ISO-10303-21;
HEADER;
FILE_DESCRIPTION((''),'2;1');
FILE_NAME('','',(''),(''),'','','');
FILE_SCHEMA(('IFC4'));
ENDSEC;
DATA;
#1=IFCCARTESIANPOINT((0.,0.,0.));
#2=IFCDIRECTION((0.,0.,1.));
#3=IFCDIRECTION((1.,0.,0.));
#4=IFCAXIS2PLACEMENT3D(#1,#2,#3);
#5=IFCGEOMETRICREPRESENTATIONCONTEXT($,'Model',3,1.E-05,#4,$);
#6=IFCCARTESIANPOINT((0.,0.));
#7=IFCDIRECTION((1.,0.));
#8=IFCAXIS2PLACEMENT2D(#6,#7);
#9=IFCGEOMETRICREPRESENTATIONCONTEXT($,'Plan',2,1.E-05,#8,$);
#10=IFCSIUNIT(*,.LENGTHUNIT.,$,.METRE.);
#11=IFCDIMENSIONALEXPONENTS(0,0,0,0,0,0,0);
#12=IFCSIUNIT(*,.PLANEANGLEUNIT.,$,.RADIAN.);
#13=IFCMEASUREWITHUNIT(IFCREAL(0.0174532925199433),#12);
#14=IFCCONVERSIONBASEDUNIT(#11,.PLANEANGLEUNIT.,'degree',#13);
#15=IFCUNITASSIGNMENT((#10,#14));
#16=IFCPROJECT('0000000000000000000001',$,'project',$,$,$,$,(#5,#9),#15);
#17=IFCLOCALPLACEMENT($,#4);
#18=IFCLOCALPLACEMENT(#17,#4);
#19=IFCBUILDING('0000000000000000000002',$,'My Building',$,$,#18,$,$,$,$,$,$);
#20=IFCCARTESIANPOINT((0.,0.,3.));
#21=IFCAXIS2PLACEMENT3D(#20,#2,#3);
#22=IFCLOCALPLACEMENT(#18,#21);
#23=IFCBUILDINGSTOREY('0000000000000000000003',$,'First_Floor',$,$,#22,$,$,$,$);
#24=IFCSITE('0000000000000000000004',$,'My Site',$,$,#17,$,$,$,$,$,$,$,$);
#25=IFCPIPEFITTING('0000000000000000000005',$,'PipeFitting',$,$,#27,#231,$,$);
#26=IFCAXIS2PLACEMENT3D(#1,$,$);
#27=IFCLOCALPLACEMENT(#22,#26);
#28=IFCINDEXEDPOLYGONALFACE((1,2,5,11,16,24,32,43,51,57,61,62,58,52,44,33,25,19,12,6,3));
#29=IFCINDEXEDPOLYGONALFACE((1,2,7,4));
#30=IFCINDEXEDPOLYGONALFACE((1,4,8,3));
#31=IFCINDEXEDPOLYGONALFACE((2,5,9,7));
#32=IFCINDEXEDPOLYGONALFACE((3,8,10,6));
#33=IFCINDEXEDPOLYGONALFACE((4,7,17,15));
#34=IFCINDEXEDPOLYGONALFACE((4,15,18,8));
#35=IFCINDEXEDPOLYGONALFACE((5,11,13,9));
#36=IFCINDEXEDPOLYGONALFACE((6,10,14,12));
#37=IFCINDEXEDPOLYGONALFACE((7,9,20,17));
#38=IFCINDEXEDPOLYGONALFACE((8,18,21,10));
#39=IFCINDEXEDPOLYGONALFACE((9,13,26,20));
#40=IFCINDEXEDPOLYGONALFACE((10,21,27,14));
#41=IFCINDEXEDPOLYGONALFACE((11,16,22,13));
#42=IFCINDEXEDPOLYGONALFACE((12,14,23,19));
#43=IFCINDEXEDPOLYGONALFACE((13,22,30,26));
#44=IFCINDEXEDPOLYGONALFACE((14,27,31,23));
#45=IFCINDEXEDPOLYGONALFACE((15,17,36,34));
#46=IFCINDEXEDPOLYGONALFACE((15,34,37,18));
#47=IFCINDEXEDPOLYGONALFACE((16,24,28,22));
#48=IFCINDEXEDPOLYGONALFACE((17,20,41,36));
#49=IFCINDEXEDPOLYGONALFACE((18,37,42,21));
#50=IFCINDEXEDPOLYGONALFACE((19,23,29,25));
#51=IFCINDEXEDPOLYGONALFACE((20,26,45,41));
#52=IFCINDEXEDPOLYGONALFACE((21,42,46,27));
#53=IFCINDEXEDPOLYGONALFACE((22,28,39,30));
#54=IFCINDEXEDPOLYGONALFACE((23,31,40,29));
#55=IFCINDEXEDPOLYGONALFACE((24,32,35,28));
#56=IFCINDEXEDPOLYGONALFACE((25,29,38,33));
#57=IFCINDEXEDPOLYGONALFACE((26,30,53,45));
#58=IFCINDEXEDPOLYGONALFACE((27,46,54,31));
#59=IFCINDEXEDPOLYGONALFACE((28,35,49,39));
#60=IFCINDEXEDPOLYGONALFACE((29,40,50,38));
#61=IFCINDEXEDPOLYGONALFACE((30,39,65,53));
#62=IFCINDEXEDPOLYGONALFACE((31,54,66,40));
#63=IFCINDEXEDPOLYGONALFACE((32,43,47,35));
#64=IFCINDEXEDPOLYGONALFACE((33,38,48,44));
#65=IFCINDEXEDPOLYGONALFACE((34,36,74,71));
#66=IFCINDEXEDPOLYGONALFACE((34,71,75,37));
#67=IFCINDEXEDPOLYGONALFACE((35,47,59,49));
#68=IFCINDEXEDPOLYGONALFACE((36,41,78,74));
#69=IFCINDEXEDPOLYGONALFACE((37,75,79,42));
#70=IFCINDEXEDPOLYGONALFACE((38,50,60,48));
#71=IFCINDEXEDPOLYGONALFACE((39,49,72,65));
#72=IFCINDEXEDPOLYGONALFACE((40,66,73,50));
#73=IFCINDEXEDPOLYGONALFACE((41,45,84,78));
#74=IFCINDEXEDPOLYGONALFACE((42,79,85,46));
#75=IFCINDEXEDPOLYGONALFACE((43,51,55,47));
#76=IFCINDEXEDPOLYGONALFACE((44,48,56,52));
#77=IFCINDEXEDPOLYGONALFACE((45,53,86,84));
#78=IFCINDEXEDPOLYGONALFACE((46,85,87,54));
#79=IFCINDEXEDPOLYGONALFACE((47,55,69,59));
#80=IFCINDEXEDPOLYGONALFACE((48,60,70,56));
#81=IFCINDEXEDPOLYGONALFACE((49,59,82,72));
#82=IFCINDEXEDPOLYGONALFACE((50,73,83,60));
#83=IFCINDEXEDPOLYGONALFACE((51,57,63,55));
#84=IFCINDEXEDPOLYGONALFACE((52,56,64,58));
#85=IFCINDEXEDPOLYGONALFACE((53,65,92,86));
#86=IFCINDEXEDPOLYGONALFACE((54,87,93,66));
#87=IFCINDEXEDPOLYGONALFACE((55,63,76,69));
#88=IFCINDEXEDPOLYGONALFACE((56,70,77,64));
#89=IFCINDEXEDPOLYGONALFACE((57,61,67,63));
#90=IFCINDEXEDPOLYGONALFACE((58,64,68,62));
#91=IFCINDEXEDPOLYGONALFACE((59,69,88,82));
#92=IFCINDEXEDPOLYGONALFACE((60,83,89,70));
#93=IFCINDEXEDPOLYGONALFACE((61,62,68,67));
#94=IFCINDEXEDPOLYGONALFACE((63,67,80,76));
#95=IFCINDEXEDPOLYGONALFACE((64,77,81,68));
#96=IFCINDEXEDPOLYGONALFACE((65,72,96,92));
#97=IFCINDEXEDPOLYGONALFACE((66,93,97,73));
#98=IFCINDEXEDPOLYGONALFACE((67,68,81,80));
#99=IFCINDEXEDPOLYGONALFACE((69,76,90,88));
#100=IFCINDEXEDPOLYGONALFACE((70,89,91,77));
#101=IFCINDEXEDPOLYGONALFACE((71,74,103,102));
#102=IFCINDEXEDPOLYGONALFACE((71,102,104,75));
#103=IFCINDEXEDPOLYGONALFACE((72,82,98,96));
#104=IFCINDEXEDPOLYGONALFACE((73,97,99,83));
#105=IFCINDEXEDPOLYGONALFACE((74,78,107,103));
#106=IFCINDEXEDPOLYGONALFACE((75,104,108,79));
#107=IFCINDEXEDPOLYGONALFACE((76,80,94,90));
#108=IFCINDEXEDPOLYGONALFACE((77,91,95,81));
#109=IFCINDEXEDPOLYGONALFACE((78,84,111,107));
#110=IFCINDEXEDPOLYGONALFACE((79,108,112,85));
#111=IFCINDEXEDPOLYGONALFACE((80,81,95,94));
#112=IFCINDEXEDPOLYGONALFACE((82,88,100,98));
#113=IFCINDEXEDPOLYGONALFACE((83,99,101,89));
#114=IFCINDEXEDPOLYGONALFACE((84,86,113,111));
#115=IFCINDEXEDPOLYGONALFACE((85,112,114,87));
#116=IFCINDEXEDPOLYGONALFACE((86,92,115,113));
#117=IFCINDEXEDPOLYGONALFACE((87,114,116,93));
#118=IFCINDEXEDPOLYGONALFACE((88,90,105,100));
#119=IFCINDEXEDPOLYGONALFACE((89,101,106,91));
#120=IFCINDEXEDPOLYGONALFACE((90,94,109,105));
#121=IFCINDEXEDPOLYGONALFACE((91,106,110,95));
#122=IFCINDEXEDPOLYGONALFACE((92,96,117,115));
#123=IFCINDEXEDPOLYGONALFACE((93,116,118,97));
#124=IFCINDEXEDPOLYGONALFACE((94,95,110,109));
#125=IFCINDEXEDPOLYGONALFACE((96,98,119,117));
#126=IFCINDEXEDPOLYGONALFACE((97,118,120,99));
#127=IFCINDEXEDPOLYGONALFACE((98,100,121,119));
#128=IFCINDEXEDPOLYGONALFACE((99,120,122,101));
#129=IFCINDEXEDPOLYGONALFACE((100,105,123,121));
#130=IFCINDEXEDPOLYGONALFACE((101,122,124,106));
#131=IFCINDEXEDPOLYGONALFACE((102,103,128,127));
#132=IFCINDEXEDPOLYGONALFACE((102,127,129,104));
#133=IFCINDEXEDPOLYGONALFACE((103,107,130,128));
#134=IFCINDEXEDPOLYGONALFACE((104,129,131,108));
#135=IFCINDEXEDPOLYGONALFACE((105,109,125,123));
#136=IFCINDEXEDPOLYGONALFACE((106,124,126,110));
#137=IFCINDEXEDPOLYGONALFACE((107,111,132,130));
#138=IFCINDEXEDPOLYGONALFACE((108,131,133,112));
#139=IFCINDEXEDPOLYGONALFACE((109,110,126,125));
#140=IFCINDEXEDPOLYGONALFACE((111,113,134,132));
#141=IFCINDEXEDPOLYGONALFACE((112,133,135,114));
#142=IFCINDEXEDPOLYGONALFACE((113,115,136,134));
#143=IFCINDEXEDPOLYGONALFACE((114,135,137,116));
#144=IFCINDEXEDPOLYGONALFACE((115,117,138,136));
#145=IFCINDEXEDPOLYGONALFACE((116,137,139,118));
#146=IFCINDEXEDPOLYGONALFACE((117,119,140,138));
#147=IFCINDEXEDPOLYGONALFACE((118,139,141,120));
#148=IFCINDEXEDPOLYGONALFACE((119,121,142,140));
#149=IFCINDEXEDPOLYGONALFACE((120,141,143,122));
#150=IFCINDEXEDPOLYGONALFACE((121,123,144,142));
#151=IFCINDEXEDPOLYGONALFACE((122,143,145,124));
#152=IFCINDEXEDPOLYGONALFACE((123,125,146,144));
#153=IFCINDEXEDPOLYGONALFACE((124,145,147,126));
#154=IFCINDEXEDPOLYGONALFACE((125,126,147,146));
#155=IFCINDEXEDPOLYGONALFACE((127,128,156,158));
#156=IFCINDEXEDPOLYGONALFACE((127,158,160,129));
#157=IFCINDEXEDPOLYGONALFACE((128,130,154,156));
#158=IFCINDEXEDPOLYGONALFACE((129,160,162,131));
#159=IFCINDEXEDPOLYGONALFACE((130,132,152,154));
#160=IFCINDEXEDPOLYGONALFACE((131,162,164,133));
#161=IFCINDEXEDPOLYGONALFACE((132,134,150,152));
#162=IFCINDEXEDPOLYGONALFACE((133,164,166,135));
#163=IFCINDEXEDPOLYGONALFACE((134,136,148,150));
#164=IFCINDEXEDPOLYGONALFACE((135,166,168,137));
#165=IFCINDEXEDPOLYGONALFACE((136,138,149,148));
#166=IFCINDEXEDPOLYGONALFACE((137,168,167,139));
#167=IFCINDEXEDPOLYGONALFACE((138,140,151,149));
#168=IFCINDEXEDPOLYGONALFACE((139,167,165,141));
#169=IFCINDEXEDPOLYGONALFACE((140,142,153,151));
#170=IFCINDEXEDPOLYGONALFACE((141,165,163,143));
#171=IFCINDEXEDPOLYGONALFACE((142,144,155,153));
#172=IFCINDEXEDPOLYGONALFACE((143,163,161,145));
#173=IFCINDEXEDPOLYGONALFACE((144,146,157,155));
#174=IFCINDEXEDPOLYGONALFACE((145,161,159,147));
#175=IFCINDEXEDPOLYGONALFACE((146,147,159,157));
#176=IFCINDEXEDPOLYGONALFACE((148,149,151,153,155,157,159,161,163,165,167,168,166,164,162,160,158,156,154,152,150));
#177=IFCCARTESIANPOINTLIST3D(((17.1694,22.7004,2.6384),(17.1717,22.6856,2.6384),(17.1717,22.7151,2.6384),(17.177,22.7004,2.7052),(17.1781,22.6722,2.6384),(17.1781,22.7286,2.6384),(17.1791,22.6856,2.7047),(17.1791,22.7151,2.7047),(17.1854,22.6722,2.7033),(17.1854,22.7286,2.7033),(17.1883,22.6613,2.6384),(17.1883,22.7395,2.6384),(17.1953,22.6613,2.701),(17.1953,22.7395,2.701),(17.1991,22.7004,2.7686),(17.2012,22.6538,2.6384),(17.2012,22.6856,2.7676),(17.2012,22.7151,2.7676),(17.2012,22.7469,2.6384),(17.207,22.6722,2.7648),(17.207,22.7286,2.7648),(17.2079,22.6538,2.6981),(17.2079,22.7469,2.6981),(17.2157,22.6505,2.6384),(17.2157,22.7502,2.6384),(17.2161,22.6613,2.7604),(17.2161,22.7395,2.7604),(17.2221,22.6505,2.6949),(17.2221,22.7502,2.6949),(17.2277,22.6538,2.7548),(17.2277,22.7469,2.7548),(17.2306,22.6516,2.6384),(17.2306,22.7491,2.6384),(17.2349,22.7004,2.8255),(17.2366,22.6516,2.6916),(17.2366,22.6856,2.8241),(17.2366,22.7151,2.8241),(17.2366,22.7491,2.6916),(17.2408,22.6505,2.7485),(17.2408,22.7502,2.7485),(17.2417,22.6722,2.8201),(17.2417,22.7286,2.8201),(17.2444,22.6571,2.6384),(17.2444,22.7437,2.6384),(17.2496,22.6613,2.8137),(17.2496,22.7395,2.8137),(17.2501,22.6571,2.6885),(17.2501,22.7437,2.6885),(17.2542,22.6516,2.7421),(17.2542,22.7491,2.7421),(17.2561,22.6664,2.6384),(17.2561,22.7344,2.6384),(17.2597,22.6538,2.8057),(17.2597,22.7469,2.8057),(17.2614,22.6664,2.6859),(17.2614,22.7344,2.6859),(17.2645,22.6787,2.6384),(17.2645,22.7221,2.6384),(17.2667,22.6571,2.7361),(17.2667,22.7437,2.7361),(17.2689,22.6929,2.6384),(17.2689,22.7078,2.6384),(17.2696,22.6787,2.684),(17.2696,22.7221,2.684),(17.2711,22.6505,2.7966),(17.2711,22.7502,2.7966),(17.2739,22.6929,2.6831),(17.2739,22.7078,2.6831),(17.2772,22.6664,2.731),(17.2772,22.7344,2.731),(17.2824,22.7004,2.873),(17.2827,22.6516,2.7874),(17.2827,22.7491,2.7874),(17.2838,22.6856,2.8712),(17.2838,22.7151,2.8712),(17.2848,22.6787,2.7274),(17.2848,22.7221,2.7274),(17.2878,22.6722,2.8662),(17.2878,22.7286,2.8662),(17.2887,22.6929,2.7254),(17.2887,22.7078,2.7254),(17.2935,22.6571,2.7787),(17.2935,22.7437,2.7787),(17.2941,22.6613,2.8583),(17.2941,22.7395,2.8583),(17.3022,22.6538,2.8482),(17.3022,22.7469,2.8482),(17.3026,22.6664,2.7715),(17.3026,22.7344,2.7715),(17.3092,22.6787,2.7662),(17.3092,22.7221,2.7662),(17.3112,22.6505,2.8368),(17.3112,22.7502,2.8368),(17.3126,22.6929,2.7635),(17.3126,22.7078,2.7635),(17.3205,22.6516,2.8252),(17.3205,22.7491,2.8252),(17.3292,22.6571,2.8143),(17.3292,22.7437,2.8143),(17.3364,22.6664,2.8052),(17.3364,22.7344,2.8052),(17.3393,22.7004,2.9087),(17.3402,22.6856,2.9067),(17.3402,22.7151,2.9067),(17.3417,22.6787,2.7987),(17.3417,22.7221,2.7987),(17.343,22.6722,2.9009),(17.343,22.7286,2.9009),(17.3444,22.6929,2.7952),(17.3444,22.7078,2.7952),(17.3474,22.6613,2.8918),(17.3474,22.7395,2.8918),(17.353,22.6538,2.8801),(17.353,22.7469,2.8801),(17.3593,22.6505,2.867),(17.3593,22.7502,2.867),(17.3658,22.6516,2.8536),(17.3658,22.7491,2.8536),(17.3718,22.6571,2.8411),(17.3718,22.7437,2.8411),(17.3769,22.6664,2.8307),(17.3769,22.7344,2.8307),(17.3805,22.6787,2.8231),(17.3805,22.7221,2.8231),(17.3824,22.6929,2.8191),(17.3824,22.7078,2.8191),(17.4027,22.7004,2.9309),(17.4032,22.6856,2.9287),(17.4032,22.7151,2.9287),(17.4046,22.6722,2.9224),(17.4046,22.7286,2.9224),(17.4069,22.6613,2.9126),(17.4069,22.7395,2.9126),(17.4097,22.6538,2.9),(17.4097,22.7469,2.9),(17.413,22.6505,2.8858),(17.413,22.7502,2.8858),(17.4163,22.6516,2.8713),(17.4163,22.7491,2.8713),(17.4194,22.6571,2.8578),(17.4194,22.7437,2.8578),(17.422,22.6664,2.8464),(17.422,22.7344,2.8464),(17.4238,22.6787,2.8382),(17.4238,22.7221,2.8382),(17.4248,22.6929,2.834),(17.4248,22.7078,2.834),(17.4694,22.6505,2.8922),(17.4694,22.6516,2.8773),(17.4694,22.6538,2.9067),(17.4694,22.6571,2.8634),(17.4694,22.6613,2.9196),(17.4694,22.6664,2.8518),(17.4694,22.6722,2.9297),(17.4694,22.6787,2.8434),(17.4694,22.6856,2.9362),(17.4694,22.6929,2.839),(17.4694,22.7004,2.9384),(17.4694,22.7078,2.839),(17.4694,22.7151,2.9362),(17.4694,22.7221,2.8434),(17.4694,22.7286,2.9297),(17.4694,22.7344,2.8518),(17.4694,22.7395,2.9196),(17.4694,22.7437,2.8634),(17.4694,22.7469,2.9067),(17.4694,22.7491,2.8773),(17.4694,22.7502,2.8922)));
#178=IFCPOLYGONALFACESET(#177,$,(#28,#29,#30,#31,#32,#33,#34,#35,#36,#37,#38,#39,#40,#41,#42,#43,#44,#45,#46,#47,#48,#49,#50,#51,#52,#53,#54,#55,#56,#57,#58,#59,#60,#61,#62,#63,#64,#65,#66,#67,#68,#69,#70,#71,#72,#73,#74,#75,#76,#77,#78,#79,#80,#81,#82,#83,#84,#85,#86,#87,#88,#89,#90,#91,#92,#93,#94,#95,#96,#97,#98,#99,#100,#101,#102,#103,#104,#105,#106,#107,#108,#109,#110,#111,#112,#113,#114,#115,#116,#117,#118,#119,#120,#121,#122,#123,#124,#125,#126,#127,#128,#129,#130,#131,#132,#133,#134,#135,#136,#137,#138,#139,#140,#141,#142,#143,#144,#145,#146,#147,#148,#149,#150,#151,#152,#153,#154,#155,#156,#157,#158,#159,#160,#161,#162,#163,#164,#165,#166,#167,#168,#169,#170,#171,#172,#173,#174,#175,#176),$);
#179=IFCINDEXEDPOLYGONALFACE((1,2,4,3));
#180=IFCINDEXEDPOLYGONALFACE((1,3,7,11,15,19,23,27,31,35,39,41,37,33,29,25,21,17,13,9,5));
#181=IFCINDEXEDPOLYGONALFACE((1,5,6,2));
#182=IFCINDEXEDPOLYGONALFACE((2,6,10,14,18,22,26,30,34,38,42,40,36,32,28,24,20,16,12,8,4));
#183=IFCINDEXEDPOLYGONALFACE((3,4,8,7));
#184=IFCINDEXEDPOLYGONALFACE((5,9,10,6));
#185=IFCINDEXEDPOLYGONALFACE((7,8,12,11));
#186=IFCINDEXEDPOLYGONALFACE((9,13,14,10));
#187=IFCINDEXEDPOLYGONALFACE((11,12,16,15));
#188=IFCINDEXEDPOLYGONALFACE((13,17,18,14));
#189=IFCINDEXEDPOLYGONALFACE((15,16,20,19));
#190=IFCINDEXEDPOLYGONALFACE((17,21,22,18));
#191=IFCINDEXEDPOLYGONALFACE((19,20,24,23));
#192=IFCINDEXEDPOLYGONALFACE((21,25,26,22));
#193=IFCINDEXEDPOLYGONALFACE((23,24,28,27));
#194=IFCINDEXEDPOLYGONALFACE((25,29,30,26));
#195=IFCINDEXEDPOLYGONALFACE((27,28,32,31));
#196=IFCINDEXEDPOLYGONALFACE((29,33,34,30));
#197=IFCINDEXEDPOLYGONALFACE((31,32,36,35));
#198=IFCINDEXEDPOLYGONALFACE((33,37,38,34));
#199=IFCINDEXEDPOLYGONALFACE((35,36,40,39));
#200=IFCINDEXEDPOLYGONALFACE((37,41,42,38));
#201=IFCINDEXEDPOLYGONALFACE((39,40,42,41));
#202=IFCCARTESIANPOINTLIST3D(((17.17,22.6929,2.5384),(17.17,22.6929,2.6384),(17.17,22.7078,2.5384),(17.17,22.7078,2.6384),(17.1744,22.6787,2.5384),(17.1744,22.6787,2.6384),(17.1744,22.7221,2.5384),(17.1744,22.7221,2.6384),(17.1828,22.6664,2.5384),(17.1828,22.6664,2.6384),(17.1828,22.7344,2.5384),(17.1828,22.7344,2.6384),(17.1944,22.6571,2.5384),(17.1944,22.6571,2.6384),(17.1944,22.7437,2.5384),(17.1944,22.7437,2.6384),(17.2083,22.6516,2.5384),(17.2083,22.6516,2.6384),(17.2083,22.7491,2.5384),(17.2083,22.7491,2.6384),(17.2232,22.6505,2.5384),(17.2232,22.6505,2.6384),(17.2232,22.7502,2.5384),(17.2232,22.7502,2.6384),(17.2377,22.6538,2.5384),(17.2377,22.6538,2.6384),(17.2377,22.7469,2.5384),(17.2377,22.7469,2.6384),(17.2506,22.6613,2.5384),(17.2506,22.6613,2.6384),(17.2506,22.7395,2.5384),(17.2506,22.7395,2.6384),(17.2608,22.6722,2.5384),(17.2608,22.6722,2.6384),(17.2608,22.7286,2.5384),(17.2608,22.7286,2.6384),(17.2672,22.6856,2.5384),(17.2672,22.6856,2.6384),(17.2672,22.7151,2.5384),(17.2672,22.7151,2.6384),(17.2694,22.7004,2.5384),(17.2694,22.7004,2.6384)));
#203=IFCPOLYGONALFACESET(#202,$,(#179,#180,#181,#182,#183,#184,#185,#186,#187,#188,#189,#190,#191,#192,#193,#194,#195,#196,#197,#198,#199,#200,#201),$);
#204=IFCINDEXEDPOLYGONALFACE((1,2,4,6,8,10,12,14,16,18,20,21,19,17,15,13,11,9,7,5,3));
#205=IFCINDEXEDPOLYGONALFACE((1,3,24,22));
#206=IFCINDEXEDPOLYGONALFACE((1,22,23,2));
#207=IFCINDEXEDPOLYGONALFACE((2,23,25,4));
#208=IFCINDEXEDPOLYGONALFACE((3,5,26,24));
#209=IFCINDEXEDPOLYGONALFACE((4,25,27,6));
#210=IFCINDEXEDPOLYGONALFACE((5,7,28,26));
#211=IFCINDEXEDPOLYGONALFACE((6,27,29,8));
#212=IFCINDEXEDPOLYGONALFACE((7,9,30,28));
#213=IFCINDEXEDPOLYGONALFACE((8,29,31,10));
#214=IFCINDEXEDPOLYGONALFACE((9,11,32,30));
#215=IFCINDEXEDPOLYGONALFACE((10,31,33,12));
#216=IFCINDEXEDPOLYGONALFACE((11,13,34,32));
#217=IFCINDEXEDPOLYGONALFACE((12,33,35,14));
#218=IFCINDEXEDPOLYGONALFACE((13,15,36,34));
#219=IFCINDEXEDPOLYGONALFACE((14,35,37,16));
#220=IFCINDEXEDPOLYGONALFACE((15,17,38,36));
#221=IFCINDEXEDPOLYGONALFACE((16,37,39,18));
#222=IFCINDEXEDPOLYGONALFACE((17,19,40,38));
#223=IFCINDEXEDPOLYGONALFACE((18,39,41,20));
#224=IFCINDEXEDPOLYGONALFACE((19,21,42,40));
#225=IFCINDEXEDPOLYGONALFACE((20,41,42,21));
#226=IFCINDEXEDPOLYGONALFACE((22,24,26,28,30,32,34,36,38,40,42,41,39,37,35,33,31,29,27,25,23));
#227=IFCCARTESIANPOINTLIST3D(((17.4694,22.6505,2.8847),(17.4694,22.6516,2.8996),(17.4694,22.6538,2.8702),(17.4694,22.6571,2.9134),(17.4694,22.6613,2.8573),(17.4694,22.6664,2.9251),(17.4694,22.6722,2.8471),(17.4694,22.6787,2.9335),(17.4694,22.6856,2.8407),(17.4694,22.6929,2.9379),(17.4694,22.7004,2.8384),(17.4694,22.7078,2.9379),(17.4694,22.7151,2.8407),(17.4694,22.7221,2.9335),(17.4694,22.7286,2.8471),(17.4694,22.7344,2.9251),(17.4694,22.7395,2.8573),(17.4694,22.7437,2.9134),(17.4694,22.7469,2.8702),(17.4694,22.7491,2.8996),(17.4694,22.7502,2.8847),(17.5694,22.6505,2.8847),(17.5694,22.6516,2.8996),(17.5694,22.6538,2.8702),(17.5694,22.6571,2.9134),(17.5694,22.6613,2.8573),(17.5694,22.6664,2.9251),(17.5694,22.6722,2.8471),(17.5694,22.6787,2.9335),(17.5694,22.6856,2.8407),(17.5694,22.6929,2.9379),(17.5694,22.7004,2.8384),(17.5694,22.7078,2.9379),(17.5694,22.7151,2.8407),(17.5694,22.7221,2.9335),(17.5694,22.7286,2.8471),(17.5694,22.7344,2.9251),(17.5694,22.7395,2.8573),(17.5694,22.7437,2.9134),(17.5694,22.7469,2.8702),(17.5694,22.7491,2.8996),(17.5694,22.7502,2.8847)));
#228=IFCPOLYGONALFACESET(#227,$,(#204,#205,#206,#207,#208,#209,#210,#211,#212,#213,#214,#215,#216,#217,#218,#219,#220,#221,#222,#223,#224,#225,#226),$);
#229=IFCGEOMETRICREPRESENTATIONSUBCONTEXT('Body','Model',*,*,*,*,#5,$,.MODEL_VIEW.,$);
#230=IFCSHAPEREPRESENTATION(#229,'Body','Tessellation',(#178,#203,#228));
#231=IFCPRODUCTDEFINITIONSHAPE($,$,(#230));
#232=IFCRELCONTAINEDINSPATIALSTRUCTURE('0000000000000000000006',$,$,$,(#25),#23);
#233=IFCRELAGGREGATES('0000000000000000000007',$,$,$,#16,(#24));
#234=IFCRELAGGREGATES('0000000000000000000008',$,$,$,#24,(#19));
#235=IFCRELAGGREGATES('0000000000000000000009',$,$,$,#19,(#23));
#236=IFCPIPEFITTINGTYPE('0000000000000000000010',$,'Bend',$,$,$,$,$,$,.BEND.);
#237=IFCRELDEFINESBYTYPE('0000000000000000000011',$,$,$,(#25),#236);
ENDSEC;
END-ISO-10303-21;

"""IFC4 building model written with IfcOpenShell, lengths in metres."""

from ifc_helpers import new_model, entity, si_unit, converted_unit, frame, origin_with_axes, origin_2d_with_axis, place, context, subcontext, project, spatial, circle, extrude, source, transform, mapped, type_object, type_shapes, element, save


model = new_model("IFC4")

# Units and contexts
model_context = context("Model", 3, precision=1e-05, world=origin_with_axes())
plan_context = context("Plan", 2, precision=1e-05, world=origin_2d_with_axis())
body_context = subcontext(model_context, "Body", "Model", "MODEL_VIEW")
ifc_project = project(units=[si_unit("LENGTHUNIT", "METRE"), converted_unit("PLANEANGLEUNIT", "degree", entity("IfcReal", 0.0174532925199433), si_unit("PLANEANGLEUNIT", "RADIAN"), dimensions=[0, 0, 0, 0, 0, 0, 0])], contexts=[model_context, plan_context])

# Site, building, storey
site_placement = place(None, origin_with_axes())
site = spatial("IfcSite", under=ifc_project, at=site_placement, Name="My Site")
building_placement = place(site_placement, origin_with_axes())
building = spatial("IfcBuilding", under=site, at=building_placement, Name="My Building")
storey_placement = place(building_placement, frame((0.0, 0.0, 3.0), z_axis=(0.0, 0.0, 1.0), x_axis=(1.0, 0.0, 0.0)))
storey = spatial("IfcBuildingStorey", under=building, at=storey_placement, Name="First_Floor")

# Pipe fitting
pipe_fitting_type = type_object("IfcPipeFittingType", Name="Bend", PredefinedType="BEND")
shared_shape = source(origin_with_axes(), body_context, "Body", "SolidModel", [
    entity("IfcSweptDiskSolid", entity("IfcIndexedPolyCurve", entity("IfcCartesianPointList3D", [[0.0, 0.0, -0.1], [0.0732, 0.0, -0.2768], [0.25, 0.0, -0.35]]), [entity("IfcArcIndex", [1, 2, 3])]), 0.05),
    extrude(circle(Radius=0.05), origin_with_axes(), (0.0, 0.0, -1.0), 0.1),
    extrude(circle(Radius=0.05), frame((0.25, 0.0, -0.35), z_axis=(1.0, 0.0, 0.0), x_axis=(0.0, 0.0, 1.0)), (0.0, 0.0, 1.0), 0.1),
])
type_shapes(pipe_fitting_type, [shared_shape])
for number, where, z_axis, x_axis, name in (
    (1, (17.2194, 22.7004, 2.5384), (0.0, 0.0, -1.0), (1.0, 0.000001, 0.0), "PipeFitting"),
):
    element("IfcPipeFitting", number, at=place(storey_placement, frame(where, z_axis=z_axis, x_axis=x_axis)), inside=storey, type_object=pipe_fitting_type, Name=name, context=body_context, shape_type="MappedRepresentation", body=[
        mapped(shared_shape, transform((0.0, 0.0, 0.0), x_axis=(1.0, 0.0, 0.0), y_axis=(0.0, 1.0, 0.0), z_axis=(0.0, 0.0, 1.0), scale=1.0)),
    ])

save(model, "model.ifc")
